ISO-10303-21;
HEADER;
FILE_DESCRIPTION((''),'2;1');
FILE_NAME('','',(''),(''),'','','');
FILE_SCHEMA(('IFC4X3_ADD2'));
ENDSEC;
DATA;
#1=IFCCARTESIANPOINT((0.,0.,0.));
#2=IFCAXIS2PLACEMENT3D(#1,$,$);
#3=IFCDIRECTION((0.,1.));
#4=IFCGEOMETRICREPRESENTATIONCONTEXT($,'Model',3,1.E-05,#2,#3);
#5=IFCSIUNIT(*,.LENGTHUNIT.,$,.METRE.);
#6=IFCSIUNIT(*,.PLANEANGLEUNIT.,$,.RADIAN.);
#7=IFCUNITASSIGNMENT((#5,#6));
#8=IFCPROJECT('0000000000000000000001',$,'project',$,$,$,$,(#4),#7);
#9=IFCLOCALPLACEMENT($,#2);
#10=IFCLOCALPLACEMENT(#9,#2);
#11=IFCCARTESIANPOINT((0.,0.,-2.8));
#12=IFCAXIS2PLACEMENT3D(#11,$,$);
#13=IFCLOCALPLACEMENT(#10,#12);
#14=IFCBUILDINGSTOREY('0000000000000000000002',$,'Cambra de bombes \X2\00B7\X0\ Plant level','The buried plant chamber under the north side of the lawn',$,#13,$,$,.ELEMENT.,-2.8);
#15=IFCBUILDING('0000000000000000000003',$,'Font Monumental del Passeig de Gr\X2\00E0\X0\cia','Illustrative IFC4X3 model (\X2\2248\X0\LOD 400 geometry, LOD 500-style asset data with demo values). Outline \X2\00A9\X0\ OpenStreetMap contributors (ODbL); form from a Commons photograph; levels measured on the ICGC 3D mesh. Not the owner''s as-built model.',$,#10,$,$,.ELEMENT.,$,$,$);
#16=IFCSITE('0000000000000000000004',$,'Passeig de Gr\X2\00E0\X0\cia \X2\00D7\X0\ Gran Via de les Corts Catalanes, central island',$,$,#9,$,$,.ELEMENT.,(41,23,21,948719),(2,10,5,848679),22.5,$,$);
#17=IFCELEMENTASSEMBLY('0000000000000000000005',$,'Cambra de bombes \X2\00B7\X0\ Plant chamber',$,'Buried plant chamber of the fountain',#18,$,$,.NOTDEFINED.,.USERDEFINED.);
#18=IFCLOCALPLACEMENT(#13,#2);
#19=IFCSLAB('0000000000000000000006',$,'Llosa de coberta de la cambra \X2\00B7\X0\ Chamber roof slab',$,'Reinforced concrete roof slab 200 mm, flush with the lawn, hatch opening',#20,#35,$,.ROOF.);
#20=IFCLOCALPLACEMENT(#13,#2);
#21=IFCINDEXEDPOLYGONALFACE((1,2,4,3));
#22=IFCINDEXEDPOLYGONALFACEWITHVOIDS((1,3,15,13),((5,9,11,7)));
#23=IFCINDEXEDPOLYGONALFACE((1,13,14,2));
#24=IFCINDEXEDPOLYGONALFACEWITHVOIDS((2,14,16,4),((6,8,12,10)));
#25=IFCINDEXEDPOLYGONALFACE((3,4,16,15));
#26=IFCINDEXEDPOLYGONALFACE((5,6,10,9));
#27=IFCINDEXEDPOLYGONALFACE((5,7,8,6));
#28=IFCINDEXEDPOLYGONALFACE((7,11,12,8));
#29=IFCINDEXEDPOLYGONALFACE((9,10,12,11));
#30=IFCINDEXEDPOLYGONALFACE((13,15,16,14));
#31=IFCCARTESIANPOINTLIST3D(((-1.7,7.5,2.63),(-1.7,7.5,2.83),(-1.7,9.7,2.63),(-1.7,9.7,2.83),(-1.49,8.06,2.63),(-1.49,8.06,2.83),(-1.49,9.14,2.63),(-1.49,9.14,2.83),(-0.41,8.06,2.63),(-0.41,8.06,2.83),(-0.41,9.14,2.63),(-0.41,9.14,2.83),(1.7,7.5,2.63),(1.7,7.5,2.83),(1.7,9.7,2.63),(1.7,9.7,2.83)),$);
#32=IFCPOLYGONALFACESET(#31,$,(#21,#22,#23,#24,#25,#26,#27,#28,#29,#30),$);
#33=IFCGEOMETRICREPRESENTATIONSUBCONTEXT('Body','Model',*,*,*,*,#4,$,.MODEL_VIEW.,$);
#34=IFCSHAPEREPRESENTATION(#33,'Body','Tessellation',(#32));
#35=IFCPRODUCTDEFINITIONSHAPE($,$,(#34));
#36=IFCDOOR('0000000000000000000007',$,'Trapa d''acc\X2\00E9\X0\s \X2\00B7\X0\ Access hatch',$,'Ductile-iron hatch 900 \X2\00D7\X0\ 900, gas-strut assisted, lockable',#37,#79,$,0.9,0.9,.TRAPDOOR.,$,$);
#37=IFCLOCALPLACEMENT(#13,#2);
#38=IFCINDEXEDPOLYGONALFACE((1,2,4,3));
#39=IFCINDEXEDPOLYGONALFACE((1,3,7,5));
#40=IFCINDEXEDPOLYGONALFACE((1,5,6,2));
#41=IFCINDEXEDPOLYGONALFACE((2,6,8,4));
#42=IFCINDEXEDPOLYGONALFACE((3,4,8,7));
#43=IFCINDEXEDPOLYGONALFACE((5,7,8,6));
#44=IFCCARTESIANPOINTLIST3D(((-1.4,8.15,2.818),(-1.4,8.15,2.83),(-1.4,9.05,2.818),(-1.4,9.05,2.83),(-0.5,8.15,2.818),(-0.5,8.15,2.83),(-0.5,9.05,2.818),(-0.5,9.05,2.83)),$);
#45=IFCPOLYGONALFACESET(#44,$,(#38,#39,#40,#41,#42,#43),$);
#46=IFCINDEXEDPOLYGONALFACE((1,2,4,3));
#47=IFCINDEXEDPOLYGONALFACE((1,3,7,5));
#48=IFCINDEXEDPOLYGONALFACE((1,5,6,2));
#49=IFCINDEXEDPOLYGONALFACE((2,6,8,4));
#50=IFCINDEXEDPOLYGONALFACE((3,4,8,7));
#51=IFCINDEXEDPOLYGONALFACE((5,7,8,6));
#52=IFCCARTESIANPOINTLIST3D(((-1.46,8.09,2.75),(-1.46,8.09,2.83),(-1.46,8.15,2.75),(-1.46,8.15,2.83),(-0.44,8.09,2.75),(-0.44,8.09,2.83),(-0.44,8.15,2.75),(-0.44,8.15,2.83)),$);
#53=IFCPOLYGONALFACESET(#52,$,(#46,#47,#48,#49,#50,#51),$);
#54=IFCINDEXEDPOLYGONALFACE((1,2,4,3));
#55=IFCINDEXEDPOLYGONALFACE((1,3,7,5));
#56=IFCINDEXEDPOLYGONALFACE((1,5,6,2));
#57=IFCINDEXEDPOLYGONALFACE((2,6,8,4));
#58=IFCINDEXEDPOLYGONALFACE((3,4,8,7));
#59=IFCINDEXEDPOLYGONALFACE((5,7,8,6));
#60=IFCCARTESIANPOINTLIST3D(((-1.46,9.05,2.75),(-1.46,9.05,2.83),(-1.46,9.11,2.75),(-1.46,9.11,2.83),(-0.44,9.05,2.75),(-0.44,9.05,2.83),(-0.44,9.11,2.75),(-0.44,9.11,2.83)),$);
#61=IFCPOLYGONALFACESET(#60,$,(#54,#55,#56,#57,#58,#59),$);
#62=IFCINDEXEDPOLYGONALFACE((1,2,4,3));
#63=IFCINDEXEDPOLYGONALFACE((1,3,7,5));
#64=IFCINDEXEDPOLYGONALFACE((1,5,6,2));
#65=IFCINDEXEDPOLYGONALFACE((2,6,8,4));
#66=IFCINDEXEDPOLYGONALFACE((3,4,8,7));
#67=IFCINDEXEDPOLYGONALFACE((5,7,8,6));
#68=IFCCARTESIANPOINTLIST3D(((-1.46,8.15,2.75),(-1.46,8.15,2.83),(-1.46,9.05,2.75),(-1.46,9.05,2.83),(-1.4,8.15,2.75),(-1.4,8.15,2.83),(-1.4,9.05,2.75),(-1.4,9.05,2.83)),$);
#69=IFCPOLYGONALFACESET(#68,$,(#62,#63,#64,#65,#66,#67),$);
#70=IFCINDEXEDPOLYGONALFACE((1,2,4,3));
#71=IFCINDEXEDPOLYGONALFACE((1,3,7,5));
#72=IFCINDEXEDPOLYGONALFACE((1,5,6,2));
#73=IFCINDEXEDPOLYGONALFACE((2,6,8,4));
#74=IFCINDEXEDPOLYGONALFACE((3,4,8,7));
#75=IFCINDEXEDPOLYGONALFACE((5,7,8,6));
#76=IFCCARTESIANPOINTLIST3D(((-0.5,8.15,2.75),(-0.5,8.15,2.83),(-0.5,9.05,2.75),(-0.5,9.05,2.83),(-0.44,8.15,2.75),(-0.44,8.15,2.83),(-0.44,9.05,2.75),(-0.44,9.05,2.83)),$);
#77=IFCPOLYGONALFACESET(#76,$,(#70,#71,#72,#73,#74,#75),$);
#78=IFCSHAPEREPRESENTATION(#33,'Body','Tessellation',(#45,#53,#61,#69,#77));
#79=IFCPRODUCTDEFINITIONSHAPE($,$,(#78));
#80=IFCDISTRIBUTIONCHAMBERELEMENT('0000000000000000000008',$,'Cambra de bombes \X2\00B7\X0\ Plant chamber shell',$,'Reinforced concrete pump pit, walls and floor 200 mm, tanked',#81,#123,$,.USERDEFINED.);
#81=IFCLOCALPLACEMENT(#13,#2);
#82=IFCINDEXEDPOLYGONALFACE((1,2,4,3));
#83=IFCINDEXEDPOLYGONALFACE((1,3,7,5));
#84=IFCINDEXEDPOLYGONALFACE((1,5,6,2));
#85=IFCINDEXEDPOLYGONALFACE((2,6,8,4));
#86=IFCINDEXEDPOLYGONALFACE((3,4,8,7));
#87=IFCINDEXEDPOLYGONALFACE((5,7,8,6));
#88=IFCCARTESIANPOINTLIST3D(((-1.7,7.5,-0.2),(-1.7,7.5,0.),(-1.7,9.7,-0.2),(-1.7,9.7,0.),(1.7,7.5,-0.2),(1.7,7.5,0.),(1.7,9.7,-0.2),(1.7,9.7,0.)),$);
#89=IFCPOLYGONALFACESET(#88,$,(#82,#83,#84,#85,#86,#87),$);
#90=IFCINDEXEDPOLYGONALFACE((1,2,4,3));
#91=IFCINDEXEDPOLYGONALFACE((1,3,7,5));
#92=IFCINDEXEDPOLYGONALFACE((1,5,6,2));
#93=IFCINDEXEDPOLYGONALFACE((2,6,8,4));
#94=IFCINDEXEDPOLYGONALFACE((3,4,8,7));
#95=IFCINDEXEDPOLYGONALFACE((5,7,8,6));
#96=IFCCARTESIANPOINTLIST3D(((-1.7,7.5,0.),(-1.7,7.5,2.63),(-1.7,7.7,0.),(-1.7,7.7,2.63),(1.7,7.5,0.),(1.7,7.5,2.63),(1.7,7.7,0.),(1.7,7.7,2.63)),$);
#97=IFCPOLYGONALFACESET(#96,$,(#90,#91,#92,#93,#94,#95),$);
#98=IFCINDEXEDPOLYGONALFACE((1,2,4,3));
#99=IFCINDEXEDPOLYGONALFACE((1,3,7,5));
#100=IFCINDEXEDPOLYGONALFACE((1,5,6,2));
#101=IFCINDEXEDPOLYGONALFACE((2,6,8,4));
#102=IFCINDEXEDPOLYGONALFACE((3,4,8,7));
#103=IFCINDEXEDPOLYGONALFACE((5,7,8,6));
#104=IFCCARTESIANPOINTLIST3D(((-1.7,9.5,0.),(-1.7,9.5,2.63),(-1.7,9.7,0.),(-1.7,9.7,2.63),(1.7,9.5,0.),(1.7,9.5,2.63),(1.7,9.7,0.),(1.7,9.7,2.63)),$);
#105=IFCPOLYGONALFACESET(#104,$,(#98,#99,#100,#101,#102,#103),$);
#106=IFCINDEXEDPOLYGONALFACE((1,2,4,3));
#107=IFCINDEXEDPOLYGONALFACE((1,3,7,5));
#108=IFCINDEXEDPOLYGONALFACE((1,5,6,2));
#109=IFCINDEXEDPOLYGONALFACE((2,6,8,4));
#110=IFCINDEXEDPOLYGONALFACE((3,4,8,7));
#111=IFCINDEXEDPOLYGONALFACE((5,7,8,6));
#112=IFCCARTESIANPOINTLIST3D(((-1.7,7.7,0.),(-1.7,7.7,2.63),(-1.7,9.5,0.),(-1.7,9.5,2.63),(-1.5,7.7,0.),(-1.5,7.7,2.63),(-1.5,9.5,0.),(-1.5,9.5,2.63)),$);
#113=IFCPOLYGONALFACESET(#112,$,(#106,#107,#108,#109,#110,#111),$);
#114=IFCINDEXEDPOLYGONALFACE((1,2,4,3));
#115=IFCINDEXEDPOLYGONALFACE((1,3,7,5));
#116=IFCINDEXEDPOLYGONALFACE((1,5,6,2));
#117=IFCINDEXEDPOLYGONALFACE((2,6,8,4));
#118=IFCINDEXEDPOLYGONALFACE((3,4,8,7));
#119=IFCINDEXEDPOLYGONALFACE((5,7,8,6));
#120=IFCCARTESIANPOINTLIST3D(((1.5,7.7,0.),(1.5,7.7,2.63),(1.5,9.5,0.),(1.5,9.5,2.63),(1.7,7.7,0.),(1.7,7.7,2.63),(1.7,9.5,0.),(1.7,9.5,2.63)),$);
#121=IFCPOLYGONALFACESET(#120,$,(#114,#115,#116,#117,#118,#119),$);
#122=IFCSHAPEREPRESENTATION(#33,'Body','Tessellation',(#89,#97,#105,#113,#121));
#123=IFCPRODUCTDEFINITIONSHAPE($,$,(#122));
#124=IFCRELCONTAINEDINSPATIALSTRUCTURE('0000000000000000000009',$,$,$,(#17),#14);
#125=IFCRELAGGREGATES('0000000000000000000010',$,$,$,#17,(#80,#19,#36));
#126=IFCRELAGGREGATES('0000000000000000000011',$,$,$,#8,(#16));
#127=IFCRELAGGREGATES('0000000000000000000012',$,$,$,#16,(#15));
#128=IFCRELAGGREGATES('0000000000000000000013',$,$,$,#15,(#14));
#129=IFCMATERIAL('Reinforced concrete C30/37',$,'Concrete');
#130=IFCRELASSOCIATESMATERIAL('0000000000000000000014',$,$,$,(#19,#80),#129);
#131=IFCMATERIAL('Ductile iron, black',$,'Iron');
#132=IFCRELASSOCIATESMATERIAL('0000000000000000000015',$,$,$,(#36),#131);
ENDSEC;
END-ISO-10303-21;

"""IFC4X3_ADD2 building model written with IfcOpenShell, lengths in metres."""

from ifc_helpers import new_model, si_unit, direction, frame, origin, origin_2d_with_axis, place, context, subcontext, project, spatial, rectangle, extrude, material, element, fill, aggregate, save


model = new_model("IFC4X3_ADD2")

# Units and contexts
model_context = context("Model", 3, precision=1e-05, world=origin(), true_north=direction((0.0, 1.0)))
body_context = subcontext(model_context, "Body", "Model", "MODEL_VIEW")
ifc_project = project(units=[si_unit("LENGTHUNIT", "METRE"), si_unit("PLANEANGLEUNIT", "RADIAN")], contexts=[model_context])

# Site, building, storey
site_placement = place(None, origin())
site = spatial("IfcSite", under=ifc_project, at=site_placement, Name="Passeig de Gràcia × Gran Via de les Corts Catalanes, central island", CompositionType="ELEMENT", RefLatitude=(41, 23, 21, 948719), RefLongitude=(2, 10, 5, 848679), RefElevation=22.5)
building_placement = place(site_placement, origin())
building = spatial("IfcBuilding", under=site, at=building_placement, Name="Font Monumental del Passeig de Gràcia", Description="Illustrative IFC4X3 model (≈LOD 400 geometry, LOD 500-style asset data with demo values). Outline © OpenStreetMap contributors (ODbL); form from a Commons photograph; levels measured on the ICGC 3D mesh. Not the owner's as-built model.", CompositionType="ELEMENT")
storey_placement = place(building_placement, frame((0.0, 0.0, -2.8)))
storey = spatial("IfcBuildingStorey", under=building, at=storey_placement, Name="Cambra de bombes · Plant level", Description="The buried plant chamber under the north side of the lawn", CompositionType="ELEMENT", Elevation=-2.8)

# Element assembly, slab, opening, door, distribution chamber element
assembly_1_placement = place(building_placement, origin())
assembly_1 = element("IfcElementAssembly", 1, at=assembly_1_placement, inside=storey, Name="Cambra de bombes · Plant chamber", ObjectType="Buried plant chamber of the fountain", AssemblyPlace="NOTDEFINED", PredefinedType="USERDEFINED")
ifc_material_1 = material(Name="Reinforced concrete C30/37", Category="Concrete")
slab_placement = place(building_placement, origin())
slab = element("IfcSlab", 2, at=slab_placement, material=ifc_material_1, Name="Llosa de coberta de la cambra · Chamber roof slab", ObjectType="Reinforced concrete roof slab 200 mm, flush with the lawn, hatch opening", PredefinedType="ROOF", context=body_context, shape_type="SweptSolid", body=[
    extrude(rectangle(XDim=3.4, YDim=2.2, at=origin_2d_with_axis()), frame((0.0, 8.6, -0.17)), (0.0, 0.0, 1.0), 0.2),
])
opening_placement = place(building_placement, origin())
opening = element("IfcOpeningElement", 3, at=opening_placement, cuts=slab, PredefinedType="OPENING", context=body_context, shape_type="SweptSolid", body=[
    extrude(rectangle(XDim=1.08, YDim=1.08, at=origin_2d_with_axis()), frame((-0.95, 8.6, -0.18)), (0.0, 0.0, 1.0), 0.22),
])
ifc_material_2 = material(Name="Ductile iron, black", Category="Iron")
door_placement = place(building_placement, origin())
door = element("IfcDoor", 4, at=door_placement, material=ifc_material_2, Name="Trapa d'accés · Access hatch", ObjectType="Ductile-iron hatch 900 × 900, gas-strut assisted, lockable", OverallHeight=0.9, OverallWidth=0.9, PredefinedType="TRAPDOOR", context=body_context, shape_type="SweptSolid", body=[
    extrude(rectangle(XDim=0.9, YDim=0.9, at=origin_2d_with_axis()), frame((-0.95, 8.6, 0.018)), (0.0, 0.0, 1.0), 0.012),
    extrude(rectangle(XDim=1.02, YDim=0.06, at=origin_2d_with_axis()), frame((-0.95, 8.12, -0.05)), (0.0, 0.0, 1.0), 0.08),
    extrude(rectangle(XDim=1.02, YDim=0.06, at=origin_2d_with_axis()), frame((-0.95, 9.08, -0.05)), (0.0, 0.0, 1.0), 0.08),
    extrude(rectangle(XDim=0.06, YDim=0.9, at=origin_2d_with_axis()), frame((-1.43, 8.6, -0.05)), (0.0, 0.0, 1.0), 0.08),
    extrude(rectangle(XDim=0.06, YDim=0.9, at=origin_2d_with_axis()), frame((-0.47, 8.6, -0.05)), (0.0, 0.0, 1.0), 0.08),
])
fill(opening, door)
distribution_chamber_element_placement = place(building_placement, origin())
distribution_chamber_element = element("IfcDistributionChamberElement", 5, at=distribution_chamber_element_placement, material=ifc_material_1, Name="Cambra de bombes · Plant chamber shell", ObjectType="Reinforced concrete pump pit, walls and floor 200 mm, tanked", PredefinedType="USERDEFINED", context=body_context, shape_type="SweptSolid", body=[
    extrude(rectangle(XDim=3.4, YDim=2.2, at=origin_2d_with_axis()), frame((0.0, 8.6, -3.0)), (0.0, 0.0, 1.0), 0.2),
    extrude(rectangle(XDim=3.4, YDim=0.2, at=origin_2d_with_axis()), frame((0.0, 7.6, -2.8)), (0.0, 0.0, 1.0), 2.63),
    extrude(rectangle(XDim=3.4, YDim=0.2, at=origin_2d_with_axis()), frame((0.0, 9.6, -2.8)), (0.0, 0.0, 1.0), 2.63),
    extrude(rectangle(XDim=0.2, YDim=1.8, at=origin_2d_with_axis()), frame((-1.6, 8.6, -2.8)), (0.0, 0.0, 1.0), 2.63),
    extrude(rectangle(XDim=0.2, YDim=1.8, at=origin_2d_with_axis()), frame((1.6, 8.6, -2.8)), (0.0, 0.0, 1.0), 2.63),
])
aggregate(assembly_1, [distribution_chamber_element, slab, door])

save(model, "model.ifc")
